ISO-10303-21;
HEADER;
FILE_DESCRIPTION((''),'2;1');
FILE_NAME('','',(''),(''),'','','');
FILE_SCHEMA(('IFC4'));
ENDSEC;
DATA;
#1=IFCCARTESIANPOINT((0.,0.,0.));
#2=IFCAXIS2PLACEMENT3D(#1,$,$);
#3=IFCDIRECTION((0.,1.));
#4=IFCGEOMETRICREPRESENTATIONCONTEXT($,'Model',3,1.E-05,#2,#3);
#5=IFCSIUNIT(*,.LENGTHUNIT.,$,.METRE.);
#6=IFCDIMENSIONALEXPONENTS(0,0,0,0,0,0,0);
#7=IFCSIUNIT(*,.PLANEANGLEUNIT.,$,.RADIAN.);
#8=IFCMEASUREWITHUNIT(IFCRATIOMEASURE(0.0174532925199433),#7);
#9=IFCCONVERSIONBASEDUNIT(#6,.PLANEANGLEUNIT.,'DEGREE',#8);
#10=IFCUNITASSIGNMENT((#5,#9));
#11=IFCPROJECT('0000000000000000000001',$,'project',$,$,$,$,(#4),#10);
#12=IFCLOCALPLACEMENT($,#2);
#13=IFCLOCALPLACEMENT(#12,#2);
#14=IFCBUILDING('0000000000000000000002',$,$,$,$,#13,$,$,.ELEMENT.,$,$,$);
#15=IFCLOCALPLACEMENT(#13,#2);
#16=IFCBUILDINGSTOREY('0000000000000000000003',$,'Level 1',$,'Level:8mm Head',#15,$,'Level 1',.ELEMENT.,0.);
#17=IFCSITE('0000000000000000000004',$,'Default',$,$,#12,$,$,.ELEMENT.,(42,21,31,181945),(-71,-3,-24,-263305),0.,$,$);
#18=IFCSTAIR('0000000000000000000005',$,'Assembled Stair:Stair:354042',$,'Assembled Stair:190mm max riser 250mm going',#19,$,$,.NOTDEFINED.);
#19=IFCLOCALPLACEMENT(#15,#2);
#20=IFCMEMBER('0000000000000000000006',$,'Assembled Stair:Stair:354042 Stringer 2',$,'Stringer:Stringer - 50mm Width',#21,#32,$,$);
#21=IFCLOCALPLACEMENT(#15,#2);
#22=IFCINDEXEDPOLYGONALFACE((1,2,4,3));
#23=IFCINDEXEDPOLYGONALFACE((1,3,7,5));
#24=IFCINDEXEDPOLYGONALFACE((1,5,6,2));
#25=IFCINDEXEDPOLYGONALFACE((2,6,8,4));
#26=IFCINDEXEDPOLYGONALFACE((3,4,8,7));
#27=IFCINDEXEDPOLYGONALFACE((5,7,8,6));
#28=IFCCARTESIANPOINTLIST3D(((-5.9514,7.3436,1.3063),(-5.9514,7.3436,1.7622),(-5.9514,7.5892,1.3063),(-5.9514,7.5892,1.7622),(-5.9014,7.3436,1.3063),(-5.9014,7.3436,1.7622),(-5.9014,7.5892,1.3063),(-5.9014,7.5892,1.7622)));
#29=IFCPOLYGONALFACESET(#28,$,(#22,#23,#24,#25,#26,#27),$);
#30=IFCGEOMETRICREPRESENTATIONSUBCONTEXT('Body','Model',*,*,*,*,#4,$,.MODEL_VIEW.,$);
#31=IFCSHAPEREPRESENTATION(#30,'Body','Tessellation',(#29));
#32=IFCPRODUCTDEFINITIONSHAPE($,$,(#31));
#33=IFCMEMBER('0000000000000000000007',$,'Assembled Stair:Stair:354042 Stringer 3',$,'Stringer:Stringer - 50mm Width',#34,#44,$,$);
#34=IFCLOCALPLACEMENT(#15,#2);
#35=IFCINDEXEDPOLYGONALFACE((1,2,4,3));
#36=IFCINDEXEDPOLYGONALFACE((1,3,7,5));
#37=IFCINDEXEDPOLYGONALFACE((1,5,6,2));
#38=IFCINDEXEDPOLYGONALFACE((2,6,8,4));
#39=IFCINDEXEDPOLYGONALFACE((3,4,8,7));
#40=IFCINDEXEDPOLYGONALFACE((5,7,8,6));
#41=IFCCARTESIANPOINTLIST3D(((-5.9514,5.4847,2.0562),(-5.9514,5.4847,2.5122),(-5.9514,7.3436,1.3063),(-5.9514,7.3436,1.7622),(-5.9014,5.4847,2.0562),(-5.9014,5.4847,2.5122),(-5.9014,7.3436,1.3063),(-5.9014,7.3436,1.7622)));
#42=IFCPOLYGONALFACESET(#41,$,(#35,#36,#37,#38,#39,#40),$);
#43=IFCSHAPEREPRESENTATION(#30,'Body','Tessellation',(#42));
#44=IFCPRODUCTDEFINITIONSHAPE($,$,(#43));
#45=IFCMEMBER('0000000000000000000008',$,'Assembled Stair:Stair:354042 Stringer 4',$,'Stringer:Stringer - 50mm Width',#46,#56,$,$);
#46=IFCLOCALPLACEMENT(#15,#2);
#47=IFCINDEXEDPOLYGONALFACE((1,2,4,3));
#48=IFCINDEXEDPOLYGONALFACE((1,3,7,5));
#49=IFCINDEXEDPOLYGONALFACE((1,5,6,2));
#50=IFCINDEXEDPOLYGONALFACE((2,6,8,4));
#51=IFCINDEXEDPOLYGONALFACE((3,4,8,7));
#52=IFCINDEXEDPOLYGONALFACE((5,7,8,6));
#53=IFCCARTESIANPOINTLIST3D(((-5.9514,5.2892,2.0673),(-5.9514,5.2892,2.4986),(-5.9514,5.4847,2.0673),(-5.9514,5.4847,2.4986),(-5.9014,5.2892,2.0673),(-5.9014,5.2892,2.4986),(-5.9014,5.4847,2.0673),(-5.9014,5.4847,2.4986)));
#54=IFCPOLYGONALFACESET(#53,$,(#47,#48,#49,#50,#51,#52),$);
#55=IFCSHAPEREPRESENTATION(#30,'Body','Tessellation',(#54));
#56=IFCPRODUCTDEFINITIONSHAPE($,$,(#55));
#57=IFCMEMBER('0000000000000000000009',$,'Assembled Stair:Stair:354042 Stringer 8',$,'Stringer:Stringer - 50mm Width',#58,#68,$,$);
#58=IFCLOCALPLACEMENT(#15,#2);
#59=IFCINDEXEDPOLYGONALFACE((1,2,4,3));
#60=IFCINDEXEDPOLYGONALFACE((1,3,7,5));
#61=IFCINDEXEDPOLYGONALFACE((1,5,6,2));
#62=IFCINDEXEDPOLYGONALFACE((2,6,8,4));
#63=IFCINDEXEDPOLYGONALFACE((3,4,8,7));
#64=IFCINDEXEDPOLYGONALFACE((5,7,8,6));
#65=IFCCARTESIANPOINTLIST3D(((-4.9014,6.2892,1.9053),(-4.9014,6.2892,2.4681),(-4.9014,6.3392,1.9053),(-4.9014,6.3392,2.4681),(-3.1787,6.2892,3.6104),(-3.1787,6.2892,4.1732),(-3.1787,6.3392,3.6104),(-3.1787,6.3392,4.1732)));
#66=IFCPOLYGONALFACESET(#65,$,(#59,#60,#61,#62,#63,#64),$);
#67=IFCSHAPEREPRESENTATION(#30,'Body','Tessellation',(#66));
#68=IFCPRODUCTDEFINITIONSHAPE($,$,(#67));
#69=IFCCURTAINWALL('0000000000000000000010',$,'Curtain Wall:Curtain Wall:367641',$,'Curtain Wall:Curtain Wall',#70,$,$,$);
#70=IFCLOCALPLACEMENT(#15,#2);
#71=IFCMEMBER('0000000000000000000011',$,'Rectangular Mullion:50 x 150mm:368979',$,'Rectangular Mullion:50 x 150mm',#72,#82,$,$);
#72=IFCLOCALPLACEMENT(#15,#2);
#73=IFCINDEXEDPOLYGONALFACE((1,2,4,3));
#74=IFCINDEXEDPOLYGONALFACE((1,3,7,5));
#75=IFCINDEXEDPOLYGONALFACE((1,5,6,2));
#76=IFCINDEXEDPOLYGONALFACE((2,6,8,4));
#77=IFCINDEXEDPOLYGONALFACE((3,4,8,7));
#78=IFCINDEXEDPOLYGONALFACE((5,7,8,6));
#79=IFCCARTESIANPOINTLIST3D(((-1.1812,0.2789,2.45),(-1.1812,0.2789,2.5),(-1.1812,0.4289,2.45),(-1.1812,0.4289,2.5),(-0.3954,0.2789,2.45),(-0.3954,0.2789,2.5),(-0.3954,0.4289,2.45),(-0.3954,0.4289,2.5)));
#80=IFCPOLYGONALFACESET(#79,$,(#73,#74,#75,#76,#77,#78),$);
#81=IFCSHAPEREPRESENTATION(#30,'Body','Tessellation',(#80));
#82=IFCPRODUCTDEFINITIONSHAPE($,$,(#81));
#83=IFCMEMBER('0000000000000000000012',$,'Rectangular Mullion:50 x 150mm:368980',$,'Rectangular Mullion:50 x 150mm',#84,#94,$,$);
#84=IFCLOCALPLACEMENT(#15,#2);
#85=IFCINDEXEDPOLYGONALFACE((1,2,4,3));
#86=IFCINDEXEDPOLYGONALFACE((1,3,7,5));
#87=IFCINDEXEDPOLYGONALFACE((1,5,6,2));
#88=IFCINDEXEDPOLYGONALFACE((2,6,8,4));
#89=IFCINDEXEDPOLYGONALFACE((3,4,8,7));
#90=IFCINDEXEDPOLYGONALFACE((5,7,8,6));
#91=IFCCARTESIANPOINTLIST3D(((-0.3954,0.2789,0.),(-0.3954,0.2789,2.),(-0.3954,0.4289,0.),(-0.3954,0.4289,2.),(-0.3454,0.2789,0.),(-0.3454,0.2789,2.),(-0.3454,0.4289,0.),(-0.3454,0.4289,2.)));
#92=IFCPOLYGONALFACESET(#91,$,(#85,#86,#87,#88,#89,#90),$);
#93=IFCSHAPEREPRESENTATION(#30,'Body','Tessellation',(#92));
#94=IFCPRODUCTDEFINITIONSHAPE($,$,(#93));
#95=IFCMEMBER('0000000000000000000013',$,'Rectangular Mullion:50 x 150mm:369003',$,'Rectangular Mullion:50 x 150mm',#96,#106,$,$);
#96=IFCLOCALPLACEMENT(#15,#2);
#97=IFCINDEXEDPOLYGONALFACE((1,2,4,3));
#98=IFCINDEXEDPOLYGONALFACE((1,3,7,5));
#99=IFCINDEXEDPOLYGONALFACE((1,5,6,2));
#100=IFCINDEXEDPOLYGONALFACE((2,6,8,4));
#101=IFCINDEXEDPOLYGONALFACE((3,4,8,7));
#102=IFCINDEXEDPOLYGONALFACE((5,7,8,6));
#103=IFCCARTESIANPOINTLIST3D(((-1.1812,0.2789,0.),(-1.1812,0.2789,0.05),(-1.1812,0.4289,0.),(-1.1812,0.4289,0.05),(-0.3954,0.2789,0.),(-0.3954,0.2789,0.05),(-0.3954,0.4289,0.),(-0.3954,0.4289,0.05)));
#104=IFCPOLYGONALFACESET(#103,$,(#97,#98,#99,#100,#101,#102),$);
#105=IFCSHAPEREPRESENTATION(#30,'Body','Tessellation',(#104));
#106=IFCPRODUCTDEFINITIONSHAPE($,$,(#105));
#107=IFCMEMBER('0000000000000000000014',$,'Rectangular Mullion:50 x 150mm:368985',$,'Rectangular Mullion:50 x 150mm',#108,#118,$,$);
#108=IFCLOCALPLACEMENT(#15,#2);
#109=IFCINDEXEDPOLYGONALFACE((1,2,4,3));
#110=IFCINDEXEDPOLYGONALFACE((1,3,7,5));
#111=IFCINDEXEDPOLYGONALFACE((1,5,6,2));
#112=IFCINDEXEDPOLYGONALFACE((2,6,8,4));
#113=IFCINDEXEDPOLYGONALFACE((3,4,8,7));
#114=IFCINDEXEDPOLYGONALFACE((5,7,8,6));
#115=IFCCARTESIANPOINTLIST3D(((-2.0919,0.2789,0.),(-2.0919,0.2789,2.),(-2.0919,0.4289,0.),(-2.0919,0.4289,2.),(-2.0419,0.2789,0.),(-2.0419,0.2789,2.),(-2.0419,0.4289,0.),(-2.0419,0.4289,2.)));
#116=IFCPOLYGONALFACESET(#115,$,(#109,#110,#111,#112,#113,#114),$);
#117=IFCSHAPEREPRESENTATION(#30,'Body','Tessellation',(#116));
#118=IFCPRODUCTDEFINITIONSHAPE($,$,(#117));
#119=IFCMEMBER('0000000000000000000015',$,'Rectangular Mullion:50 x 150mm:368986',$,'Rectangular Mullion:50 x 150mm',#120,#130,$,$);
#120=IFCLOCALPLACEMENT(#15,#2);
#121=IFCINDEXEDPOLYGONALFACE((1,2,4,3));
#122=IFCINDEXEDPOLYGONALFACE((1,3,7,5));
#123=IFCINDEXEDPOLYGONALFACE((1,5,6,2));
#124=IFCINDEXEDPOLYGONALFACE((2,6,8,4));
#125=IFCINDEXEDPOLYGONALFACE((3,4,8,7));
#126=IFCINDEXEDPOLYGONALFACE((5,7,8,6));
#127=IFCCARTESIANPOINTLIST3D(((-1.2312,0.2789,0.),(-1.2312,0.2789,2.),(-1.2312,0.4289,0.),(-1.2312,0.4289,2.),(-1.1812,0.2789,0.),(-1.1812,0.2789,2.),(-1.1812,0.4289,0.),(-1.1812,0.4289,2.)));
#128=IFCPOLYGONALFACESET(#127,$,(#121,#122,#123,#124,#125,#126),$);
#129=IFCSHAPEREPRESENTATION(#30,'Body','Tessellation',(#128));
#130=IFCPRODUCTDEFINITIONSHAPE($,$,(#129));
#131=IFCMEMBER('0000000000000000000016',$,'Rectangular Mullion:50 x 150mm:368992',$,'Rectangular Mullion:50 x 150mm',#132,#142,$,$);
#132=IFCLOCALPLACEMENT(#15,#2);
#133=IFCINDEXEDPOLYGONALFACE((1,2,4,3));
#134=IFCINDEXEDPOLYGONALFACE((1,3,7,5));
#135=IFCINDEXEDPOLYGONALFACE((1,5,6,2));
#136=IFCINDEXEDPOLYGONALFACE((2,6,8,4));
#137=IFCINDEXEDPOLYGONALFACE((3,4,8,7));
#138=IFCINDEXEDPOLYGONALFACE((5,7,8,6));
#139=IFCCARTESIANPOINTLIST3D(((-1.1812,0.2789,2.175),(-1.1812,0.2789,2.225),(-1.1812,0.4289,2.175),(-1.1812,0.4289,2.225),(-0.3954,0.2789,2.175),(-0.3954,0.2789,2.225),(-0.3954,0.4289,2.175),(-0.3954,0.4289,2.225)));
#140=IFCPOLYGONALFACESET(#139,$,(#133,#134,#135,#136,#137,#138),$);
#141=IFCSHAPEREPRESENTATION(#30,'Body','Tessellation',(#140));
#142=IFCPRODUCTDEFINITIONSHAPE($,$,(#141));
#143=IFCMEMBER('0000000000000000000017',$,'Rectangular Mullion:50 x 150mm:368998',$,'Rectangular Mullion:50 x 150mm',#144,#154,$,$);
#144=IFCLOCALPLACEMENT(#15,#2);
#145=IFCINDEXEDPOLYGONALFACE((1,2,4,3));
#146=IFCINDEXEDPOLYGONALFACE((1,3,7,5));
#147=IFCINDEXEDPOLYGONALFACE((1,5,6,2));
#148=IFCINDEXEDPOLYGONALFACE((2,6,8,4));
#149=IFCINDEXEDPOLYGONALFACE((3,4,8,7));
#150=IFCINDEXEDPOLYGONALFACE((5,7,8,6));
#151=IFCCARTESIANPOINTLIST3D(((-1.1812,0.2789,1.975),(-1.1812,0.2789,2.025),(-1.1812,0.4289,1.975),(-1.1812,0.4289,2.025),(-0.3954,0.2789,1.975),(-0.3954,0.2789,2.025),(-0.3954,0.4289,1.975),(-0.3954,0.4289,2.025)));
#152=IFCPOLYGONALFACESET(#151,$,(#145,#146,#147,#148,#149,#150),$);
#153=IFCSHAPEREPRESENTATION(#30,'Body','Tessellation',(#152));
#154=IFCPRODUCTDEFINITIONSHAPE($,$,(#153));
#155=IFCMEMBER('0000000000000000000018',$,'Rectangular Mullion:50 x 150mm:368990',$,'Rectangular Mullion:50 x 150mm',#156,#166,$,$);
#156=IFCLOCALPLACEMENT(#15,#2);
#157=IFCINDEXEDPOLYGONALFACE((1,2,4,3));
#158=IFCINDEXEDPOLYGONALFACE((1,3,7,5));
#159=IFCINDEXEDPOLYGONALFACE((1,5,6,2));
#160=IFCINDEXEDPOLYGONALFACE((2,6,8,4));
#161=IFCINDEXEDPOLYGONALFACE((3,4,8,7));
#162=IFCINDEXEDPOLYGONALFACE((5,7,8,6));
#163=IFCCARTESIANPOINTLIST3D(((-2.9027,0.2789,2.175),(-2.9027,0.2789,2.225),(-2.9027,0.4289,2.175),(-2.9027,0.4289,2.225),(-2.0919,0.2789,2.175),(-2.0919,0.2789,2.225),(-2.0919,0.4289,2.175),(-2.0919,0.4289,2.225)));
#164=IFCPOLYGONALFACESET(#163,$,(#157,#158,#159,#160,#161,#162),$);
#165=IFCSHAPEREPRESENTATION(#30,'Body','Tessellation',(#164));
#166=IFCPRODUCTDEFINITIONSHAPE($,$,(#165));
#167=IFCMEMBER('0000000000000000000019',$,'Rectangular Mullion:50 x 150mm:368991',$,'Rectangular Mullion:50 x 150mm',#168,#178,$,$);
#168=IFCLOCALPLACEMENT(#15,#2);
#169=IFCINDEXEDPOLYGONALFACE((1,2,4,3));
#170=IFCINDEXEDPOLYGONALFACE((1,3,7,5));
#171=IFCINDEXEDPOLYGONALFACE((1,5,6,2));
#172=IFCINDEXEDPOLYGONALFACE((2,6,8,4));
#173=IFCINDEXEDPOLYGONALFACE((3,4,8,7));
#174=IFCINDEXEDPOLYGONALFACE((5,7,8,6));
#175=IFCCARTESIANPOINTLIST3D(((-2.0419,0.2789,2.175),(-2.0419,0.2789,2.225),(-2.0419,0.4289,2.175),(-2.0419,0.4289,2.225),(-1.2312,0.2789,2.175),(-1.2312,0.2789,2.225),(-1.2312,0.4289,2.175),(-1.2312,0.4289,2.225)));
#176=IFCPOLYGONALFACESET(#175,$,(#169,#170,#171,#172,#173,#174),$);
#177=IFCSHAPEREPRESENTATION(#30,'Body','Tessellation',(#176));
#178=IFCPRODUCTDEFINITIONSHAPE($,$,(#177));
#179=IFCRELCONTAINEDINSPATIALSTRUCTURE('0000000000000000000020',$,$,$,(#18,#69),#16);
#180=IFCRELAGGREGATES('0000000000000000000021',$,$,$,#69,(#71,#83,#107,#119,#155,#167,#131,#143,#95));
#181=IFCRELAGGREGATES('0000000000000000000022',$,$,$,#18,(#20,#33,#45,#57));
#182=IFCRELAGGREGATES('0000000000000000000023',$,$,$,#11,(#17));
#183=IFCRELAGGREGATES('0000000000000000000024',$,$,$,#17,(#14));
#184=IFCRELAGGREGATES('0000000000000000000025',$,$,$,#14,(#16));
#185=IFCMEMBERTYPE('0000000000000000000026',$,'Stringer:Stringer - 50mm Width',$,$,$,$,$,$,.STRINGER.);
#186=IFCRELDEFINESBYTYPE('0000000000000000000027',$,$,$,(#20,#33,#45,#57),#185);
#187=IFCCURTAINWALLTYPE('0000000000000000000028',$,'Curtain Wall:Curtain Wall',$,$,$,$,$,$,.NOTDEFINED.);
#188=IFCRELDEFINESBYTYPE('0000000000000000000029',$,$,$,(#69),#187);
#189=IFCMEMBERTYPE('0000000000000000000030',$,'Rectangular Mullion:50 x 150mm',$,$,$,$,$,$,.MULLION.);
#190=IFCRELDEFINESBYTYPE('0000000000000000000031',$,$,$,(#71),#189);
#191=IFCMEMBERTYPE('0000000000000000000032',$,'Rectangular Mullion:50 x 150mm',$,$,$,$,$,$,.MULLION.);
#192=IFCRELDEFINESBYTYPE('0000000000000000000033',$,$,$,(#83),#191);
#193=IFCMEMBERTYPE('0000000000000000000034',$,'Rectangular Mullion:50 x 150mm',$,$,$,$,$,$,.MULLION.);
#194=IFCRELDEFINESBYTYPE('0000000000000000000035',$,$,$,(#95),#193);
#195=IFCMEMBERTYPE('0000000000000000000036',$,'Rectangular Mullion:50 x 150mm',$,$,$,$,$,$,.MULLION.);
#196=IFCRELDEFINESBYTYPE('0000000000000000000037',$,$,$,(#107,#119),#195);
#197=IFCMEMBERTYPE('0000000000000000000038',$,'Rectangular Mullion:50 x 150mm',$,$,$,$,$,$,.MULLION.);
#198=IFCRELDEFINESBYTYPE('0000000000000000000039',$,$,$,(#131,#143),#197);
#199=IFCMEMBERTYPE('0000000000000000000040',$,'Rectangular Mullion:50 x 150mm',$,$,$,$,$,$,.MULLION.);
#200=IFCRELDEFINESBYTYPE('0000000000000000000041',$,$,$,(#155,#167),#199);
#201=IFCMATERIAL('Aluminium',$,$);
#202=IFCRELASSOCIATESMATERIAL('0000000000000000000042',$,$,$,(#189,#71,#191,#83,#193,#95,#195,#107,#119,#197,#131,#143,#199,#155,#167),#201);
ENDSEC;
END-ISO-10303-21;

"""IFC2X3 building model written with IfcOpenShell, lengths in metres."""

from ifc_helpers import new_model, entity, si_unit, converted_unit, direction, frame, frame_2d, origin, origin_2d_with_axis, place, context, subcontext, project, spatial, polyline, rectangle, outline, extrude, source, transform, mapped, material, type_object, type_shapes, element, aggregate, save


model = new_model("IFC2X3")

# Units and contexts
model_context = context("Model", 3, precision=1e-05, world=origin(), true_north=direction((0.0, 1.0)))
body_context = subcontext(model_context, "Body", "Model", "MODEL_VIEW")
ifc_project = project(units=[si_unit("LENGTHUNIT", "METRE"), converted_unit("PLANEANGLEUNIT", "DEGREE", entity("IfcRatioMeasure", 0.0174532925199433), si_unit("PLANEANGLEUNIT", "RADIAN"), dimensions=[0, 0, 0, 0, 0, 0, 0])], contexts=[model_context])

# Site, building, storey
site_placement = place(None, origin())
site = spatial("IfcSite", under=ifc_project, at=site_placement, Name="Default", CompositionType="ELEMENT", RefLatitude=(42, 21, 31, 181945), RefLongitude=(-71, -3, -24, -263305), RefElevation=0.0)
building_placement = place(site_placement, origin())
building = spatial("IfcBuilding", under=site, at=building_placement, CompositionType="ELEMENT")
storey_placement = place(building_placement, origin())
storey = spatial("IfcBuildingStorey", under=building, at=storey_placement, Name="Level 1", ObjectType="Level:8mm Head", LongName="Level 1", CompositionType="ELEMENT", Elevation=0.0)

# Stair, members
stair_placement = place(storey_placement, origin())
stair = element("IfcStair", 1, at=stair_placement, inside=storey, Name="Assembled Stair:Stair:354042", ObjectType="Assembled Stair:190mm max riser 250mm going", ShapeType="NOTDEFINED")
member_type_1 = type_object("IfcMemberType", Name="Stringer:Stringer - 50mm Width", PredefinedType="STRINGER")
member_1_placement = place(stair_placement, origin())
member_1 = element("IfcMember", 2, at=member_1_placement, type_object=member_type_1, Name="Assembled Stair:Stair:354042 Stringer 2", ObjectType="Stringer:Stringer - 50mm Width", context=body_context, shape_type="SweptSolid", body=[
    extrude(rectangle(XDim=0.2455, YDim=0.05, at=frame_2d((0.0, 0.0), x_axis=(1.0, 0.0))), frame((-5.9264, 7.4664, 1.3063), z_axis=(0.0, 0.0, 1.0), x_axis=(0.0, -1.0, 0.0)), (0.0, 0.0, 1.0), 0.4559),
])
member_2_placement = place(stair_placement, origin())
member_2 = element("IfcMember", 3, at=member_2_placement, type_object=member_type_1, Name="Assembled Stair:Stair:354042 Stringer 3", ObjectType="Stringer:Stringer - 50mm Width", context=body_context, shape_type="SweptSolid", body=[
    extrude(outline(polyline([(-0.917, -0.2114), (1.0875, -0.2114), (0.917, 0.2114), (-1.0875, 0.2114), (-0.917, -0.2114)])), frame((-5.9514, 6.4142, 1.9092), z_axis=(1.0, 0.0, 0.0), x_axis=(0.0, -0.927382, 0.374115)), (0.0, 0.0, 1.0), 0.05),
])
member_3_placement = place(stair_placement, origin())
member_3 = element("IfcMember", 4, at=member_3_placement, type_object=member_type_1, Name="Assembled Stair:Stair:354042 Stringer 4", ObjectType="Stringer:Stringer - 50mm Width", context=body_context, shape_type="SweptSolid", body=[
    extrude(rectangle(XDim=0.1955, YDim=0.05, at=origin_2d_with_axis()), frame((-5.9264, 5.3869, 2.0673), z_axis=(0.0, 0.0, 1.0), x_axis=(0.0, -1.0, 0.0)), (0.0, 0.0, 1.0), 0.4313),
])
member_4_placement = place(stair_placement, origin())
member_4 = element("IfcMember", 5, at=member_4_placement, type_object=member_type_1, Name="Assembled Stair:Stair:354042 Stringer 8", ObjectType="Stringer:Stringer - 50mm Width", context=body_context, shape_type="SweptSolid", body=[
    extrude(outline(polyline([(-1.014, -0.2), (1.4099, -0.2), (1.014, 0.2), (-1.4099, 0.2), (-1.014, -0.2)])), frame((-4.0401, 6.2892, 3.0392), z_axis=(0.0, 1.0, 0.0), x_axis=(0.710714, 0.0, 0.703481)), (0.0, 0.0, 1.0), 0.05),
])

# Curtain wall, members
curtain_wall_type = type_object("IfcCurtainWallType", Name="Curtain Wall:Curtain Wall", PredefinedType="NOTDEFINED")
curtain_wall_placement = place(storey_placement, origin())
curtain_wall = element("IfcCurtainWall", 6, at=curtain_wall_placement, inside=storey, type_object=curtain_wall_type, Name="Curtain Wall:Curtain Wall:367641", ObjectType="Curtain Wall:Curtain Wall")
ifc_material_1 = material(Name="Aluminium")
member_type_2 = type_object("IfcMemberType", Name="Rectangular Mullion:50 x 150mm", PredefinedType="MULLION", material=ifc_material_1)
shared_shape_1 = source(origin(), body_context, "Body", "SweptSolid", [
    extrude(rectangle(XDim=0.15, YDim=0.05, at=origin_2d_with_axis()), frame((-0.025, 0.0, -0.7857), z_axis=(0.0, 0.0, 1.0), x_axis=(0.0, -1.0, 0.0)), (0.0, 0.0, 1.0), 0.7857),
])
type_shapes(member_type_2, [shared_shape_1])
member_5_placement = place(storey_placement, frame((-0.3954, 0.3539, 2.5), z_axis=(1.0, 0.0, 0.0), x_axis=(0.0, 0.0, 1.0)))
member_5 = element("IfcMember", 7, at=member_5_placement, type_object=member_type_2, material=ifc_material_1, Name="Rectangular Mullion:50 x 150mm:368979", ObjectType="Rectangular Mullion:50 x 150mm", context=body_context, shape_type="MappedRepresentation", body=[
    mapped(shared_shape_1, transform((0.0, 0.0, 0.0), scale=1.0)),
])
member_type_3 = type_object("IfcMemberType", Name="Rectangular Mullion:50 x 150mm", PredefinedType="MULLION", material=ifc_material_1)
shared_shape_2 = source(origin(), body_context, "Body", "SweptSolid", [
    extrude(rectangle(XDim=0.15, YDim=0.05, at=origin_2d_with_axis()), frame((-0.025, 0.0, -2.0), z_axis=(0.0, 0.0, 1.0), x_axis=(0.0, -1.0, 0.0)), (0.0, 0.0, 1.0), 2.0),
])
type_shapes(member_type_3, [shared_shape_2])
member_6_placement = place(storey_placement, frame((-0.3454, 0.3539, 0.0), z_axis=(0.0, 0.0, -1.0), x_axis=(1.0, 0.0, 0.0)))
member_6 = element("IfcMember", 8, at=member_6_placement, type_object=member_type_3, material=ifc_material_1, Name="Rectangular Mullion:50 x 150mm:368980", ObjectType="Rectangular Mullion:50 x 150mm", context=body_context, shape_type="MappedRepresentation", body=[
    mapped(shared_shape_2, transform((0.0, 0.0, 0.0), scale=1.0)),
])
member_type_4 = type_object("IfcMemberType", Name="Rectangular Mullion:50 x 150mm", PredefinedType="MULLION", material=ifc_material_1)
shared_shape_3 = source(origin(), body_context, "Body", "SweptSolid", [
    extrude(rectangle(XDim=0.15, YDim=0.05, at=origin_2d_with_axis()), frame((-0.025, 0.0, -0.7857), z_axis=(0.0, 0.0, 1.0), x_axis=(0.0, -1.0, 0.0)), (0.0, 0.0, 1.0), 0.7857),
])
type_shapes(member_type_4, [shared_shape_3])
member_7_placement = place(storey_placement, frame((-1.1812, 0.3539, 0.0), z_axis=(-1.0, 0.0, 0.0), x_axis=(0.0, 0.0, -1.0)))
member_7 = element("IfcMember", 9, at=member_7_placement, type_object=member_type_4, material=ifc_material_1, Name="Rectangular Mullion:50 x 150mm:369003", ObjectType="Rectangular Mullion:50 x 150mm", context=body_context, shape_type="MappedRepresentation", body=[
    mapped(shared_shape_3, transform((0.0, 0.0, 0.0), scale=1.0)),
])
member_type_5 = type_object("IfcMemberType", Name="Rectangular Mullion:50 x 150mm", PredefinedType="MULLION", material=ifc_material_1)
shared_shape_4 = source(origin(), body_context, "Body", "SweptSolid", [
    extrude(rectangle(XDim=0.15, YDim=0.05, at=origin_2d_with_axis()), frame((0.0, 0.0, -2.0), z_axis=(0.0, 0.0, 1.0), x_axis=(0.0, -1.0, 0.0)), (0.0, 0.0, 1.0), 2.0),
])
type_shapes(member_type_5, [shared_shape_4])
member_8_placement = place(storey_placement, frame((-2.0669, 0.3539, 0.0), z_axis=(0.0, 0.0, -1.0), x_axis=(1.0, 0.0, 0.0)))
member_8 = element("IfcMember", 10, at=member_8_placement, type_object=member_type_5, material=ifc_material_1, Name="Rectangular Mullion:50 x 150mm:368985", ObjectType="Rectangular Mullion:50 x 150mm", context=body_context, shape_type="MappedRepresentation", body=[
    mapped(shared_shape_4, transform((0.0, 0.0, 0.0), scale=1.0)),
])
member_9_placement = place(storey_placement, frame((-1.2062, 0.3539, 0.0), z_axis=(0.0, 0.0, -1.0), x_axis=(1.0, 0.0, 0.0)))
member_9 = element("IfcMember", 11, at=member_9_placement, type_object=member_type_5, material=ifc_material_1, Name="Rectangular Mullion:50 x 150mm:368986", ObjectType="Rectangular Mullion:50 x 150mm", context=body_context, shape_type="MappedRepresentation", body=[
    mapped(shared_shape_4, transform((0.0, 0.0, 0.0), scale=1.0)),
])
member_type_6 = type_object("IfcMemberType", Name="Rectangular Mullion:50 x 150mm", PredefinedType="MULLION", material=ifc_material_1)
shared_shape_5 = source(origin(), body_context, "Body", "SweptSolid", [
    extrude(rectangle(XDim=0.15, YDim=0.05, at=origin_2d_with_axis()), frame((0.0, 0.0, -0.7857), z_axis=(0.0, 0.0, 1.0), x_axis=(0.0, -1.0, 0.0)), (0.0, 0.0, 1.0), 0.7857),
])
type_shapes(member_type_6, [shared_shape_5])
member_10_placement = place(storey_placement, frame((-0.3954, 0.3539, 2.2), z_axis=(1.0, 0.0, 0.0), x_axis=(0.0, 0.0, 1.0)))
member_10 = element("IfcMember", 12, at=member_10_placement, type_object=member_type_6, material=ifc_material_1, Name="Rectangular Mullion:50 x 150mm:368992", ObjectType="Rectangular Mullion:50 x 150mm", context=body_context, shape_type="MappedRepresentation", body=[
    mapped(shared_shape_5, transform((0.0, 0.0, 0.0), scale=1.0)),
])
member_11_placement = place(storey_placement, frame((-0.3954, 0.3539, 2.0), z_axis=(1.0, 0.0, 0.0), x_axis=(0.0, 0.0, 1.0)))
member_11 = element("IfcMember", 13, at=member_11_placement, type_object=member_type_6, material=ifc_material_1, Name="Rectangular Mullion:50 x 150mm:368998", ObjectType="Rectangular Mullion:50 x 150mm", context=body_context, shape_type="MappedRepresentation", body=[
    mapped(shared_shape_5, transform((0.0, 0.0, 0.0), scale=1.0)),
])
member_type_7 = type_object("IfcMemberType", Name="Rectangular Mullion:50 x 150mm", PredefinedType="MULLION", material=ifc_material_1)
shared_shape_6 = source(origin(), body_context, "Body", "SweptSolid", [
    extrude(rectangle(XDim=0.15, YDim=0.05, at=origin_2d_with_axis()), frame((0.0, 0.0, -0.8107), z_axis=(0.0, 0.0, 1.0), x_axis=(0.0, -1.0, 0.0)), (0.0, 0.0, 1.0), 0.8107),
])
type_shapes(member_type_7, [shared_shape_6])
member_12_placement = place(storey_placement, frame((-2.0919, 0.3539, 2.2), z_axis=(1.0, 0.0, 0.0), x_axis=(0.0, 0.0, 1.0)))
member_12 = element("IfcMember", 14, at=member_12_placement, type_object=member_type_7, material=ifc_material_1, Name="Rectangular Mullion:50 x 150mm:368990", ObjectType="Rectangular Mullion:50 x 150mm", context=body_context, shape_type="MappedRepresentation", body=[
    mapped(shared_shape_6, transform((0.0, 0.0, 0.0), scale=1.0)),
])
member_13_placement = place(storey_placement, frame((-1.2312, 0.3539, 2.2), z_axis=(1.0, 0.0, 0.0), x_axis=(0.0, 0.0, 1.0)))
member_13 = element("IfcMember", 15, at=member_13_placement, type_object=member_type_7, material=ifc_material_1, Name="Rectangular Mullion:50 x 150mm:368991", ObjectType="Rectangular Mullion:50 x 150mm", context=body_context, shape_type="MappedRepresentation", body=[
    mapped(shared_shape_6, transform((0.0, 0.0, 0.0), scale=1.0)),
])

aggregate(curtain_wall, [member_5, member_6, member_8, member_9, member_12, member_13, member_10, member_11, member_7])

aggregate(stair, [member_1, member_2, member_3, member_4])

save(model, "model.ifc")
